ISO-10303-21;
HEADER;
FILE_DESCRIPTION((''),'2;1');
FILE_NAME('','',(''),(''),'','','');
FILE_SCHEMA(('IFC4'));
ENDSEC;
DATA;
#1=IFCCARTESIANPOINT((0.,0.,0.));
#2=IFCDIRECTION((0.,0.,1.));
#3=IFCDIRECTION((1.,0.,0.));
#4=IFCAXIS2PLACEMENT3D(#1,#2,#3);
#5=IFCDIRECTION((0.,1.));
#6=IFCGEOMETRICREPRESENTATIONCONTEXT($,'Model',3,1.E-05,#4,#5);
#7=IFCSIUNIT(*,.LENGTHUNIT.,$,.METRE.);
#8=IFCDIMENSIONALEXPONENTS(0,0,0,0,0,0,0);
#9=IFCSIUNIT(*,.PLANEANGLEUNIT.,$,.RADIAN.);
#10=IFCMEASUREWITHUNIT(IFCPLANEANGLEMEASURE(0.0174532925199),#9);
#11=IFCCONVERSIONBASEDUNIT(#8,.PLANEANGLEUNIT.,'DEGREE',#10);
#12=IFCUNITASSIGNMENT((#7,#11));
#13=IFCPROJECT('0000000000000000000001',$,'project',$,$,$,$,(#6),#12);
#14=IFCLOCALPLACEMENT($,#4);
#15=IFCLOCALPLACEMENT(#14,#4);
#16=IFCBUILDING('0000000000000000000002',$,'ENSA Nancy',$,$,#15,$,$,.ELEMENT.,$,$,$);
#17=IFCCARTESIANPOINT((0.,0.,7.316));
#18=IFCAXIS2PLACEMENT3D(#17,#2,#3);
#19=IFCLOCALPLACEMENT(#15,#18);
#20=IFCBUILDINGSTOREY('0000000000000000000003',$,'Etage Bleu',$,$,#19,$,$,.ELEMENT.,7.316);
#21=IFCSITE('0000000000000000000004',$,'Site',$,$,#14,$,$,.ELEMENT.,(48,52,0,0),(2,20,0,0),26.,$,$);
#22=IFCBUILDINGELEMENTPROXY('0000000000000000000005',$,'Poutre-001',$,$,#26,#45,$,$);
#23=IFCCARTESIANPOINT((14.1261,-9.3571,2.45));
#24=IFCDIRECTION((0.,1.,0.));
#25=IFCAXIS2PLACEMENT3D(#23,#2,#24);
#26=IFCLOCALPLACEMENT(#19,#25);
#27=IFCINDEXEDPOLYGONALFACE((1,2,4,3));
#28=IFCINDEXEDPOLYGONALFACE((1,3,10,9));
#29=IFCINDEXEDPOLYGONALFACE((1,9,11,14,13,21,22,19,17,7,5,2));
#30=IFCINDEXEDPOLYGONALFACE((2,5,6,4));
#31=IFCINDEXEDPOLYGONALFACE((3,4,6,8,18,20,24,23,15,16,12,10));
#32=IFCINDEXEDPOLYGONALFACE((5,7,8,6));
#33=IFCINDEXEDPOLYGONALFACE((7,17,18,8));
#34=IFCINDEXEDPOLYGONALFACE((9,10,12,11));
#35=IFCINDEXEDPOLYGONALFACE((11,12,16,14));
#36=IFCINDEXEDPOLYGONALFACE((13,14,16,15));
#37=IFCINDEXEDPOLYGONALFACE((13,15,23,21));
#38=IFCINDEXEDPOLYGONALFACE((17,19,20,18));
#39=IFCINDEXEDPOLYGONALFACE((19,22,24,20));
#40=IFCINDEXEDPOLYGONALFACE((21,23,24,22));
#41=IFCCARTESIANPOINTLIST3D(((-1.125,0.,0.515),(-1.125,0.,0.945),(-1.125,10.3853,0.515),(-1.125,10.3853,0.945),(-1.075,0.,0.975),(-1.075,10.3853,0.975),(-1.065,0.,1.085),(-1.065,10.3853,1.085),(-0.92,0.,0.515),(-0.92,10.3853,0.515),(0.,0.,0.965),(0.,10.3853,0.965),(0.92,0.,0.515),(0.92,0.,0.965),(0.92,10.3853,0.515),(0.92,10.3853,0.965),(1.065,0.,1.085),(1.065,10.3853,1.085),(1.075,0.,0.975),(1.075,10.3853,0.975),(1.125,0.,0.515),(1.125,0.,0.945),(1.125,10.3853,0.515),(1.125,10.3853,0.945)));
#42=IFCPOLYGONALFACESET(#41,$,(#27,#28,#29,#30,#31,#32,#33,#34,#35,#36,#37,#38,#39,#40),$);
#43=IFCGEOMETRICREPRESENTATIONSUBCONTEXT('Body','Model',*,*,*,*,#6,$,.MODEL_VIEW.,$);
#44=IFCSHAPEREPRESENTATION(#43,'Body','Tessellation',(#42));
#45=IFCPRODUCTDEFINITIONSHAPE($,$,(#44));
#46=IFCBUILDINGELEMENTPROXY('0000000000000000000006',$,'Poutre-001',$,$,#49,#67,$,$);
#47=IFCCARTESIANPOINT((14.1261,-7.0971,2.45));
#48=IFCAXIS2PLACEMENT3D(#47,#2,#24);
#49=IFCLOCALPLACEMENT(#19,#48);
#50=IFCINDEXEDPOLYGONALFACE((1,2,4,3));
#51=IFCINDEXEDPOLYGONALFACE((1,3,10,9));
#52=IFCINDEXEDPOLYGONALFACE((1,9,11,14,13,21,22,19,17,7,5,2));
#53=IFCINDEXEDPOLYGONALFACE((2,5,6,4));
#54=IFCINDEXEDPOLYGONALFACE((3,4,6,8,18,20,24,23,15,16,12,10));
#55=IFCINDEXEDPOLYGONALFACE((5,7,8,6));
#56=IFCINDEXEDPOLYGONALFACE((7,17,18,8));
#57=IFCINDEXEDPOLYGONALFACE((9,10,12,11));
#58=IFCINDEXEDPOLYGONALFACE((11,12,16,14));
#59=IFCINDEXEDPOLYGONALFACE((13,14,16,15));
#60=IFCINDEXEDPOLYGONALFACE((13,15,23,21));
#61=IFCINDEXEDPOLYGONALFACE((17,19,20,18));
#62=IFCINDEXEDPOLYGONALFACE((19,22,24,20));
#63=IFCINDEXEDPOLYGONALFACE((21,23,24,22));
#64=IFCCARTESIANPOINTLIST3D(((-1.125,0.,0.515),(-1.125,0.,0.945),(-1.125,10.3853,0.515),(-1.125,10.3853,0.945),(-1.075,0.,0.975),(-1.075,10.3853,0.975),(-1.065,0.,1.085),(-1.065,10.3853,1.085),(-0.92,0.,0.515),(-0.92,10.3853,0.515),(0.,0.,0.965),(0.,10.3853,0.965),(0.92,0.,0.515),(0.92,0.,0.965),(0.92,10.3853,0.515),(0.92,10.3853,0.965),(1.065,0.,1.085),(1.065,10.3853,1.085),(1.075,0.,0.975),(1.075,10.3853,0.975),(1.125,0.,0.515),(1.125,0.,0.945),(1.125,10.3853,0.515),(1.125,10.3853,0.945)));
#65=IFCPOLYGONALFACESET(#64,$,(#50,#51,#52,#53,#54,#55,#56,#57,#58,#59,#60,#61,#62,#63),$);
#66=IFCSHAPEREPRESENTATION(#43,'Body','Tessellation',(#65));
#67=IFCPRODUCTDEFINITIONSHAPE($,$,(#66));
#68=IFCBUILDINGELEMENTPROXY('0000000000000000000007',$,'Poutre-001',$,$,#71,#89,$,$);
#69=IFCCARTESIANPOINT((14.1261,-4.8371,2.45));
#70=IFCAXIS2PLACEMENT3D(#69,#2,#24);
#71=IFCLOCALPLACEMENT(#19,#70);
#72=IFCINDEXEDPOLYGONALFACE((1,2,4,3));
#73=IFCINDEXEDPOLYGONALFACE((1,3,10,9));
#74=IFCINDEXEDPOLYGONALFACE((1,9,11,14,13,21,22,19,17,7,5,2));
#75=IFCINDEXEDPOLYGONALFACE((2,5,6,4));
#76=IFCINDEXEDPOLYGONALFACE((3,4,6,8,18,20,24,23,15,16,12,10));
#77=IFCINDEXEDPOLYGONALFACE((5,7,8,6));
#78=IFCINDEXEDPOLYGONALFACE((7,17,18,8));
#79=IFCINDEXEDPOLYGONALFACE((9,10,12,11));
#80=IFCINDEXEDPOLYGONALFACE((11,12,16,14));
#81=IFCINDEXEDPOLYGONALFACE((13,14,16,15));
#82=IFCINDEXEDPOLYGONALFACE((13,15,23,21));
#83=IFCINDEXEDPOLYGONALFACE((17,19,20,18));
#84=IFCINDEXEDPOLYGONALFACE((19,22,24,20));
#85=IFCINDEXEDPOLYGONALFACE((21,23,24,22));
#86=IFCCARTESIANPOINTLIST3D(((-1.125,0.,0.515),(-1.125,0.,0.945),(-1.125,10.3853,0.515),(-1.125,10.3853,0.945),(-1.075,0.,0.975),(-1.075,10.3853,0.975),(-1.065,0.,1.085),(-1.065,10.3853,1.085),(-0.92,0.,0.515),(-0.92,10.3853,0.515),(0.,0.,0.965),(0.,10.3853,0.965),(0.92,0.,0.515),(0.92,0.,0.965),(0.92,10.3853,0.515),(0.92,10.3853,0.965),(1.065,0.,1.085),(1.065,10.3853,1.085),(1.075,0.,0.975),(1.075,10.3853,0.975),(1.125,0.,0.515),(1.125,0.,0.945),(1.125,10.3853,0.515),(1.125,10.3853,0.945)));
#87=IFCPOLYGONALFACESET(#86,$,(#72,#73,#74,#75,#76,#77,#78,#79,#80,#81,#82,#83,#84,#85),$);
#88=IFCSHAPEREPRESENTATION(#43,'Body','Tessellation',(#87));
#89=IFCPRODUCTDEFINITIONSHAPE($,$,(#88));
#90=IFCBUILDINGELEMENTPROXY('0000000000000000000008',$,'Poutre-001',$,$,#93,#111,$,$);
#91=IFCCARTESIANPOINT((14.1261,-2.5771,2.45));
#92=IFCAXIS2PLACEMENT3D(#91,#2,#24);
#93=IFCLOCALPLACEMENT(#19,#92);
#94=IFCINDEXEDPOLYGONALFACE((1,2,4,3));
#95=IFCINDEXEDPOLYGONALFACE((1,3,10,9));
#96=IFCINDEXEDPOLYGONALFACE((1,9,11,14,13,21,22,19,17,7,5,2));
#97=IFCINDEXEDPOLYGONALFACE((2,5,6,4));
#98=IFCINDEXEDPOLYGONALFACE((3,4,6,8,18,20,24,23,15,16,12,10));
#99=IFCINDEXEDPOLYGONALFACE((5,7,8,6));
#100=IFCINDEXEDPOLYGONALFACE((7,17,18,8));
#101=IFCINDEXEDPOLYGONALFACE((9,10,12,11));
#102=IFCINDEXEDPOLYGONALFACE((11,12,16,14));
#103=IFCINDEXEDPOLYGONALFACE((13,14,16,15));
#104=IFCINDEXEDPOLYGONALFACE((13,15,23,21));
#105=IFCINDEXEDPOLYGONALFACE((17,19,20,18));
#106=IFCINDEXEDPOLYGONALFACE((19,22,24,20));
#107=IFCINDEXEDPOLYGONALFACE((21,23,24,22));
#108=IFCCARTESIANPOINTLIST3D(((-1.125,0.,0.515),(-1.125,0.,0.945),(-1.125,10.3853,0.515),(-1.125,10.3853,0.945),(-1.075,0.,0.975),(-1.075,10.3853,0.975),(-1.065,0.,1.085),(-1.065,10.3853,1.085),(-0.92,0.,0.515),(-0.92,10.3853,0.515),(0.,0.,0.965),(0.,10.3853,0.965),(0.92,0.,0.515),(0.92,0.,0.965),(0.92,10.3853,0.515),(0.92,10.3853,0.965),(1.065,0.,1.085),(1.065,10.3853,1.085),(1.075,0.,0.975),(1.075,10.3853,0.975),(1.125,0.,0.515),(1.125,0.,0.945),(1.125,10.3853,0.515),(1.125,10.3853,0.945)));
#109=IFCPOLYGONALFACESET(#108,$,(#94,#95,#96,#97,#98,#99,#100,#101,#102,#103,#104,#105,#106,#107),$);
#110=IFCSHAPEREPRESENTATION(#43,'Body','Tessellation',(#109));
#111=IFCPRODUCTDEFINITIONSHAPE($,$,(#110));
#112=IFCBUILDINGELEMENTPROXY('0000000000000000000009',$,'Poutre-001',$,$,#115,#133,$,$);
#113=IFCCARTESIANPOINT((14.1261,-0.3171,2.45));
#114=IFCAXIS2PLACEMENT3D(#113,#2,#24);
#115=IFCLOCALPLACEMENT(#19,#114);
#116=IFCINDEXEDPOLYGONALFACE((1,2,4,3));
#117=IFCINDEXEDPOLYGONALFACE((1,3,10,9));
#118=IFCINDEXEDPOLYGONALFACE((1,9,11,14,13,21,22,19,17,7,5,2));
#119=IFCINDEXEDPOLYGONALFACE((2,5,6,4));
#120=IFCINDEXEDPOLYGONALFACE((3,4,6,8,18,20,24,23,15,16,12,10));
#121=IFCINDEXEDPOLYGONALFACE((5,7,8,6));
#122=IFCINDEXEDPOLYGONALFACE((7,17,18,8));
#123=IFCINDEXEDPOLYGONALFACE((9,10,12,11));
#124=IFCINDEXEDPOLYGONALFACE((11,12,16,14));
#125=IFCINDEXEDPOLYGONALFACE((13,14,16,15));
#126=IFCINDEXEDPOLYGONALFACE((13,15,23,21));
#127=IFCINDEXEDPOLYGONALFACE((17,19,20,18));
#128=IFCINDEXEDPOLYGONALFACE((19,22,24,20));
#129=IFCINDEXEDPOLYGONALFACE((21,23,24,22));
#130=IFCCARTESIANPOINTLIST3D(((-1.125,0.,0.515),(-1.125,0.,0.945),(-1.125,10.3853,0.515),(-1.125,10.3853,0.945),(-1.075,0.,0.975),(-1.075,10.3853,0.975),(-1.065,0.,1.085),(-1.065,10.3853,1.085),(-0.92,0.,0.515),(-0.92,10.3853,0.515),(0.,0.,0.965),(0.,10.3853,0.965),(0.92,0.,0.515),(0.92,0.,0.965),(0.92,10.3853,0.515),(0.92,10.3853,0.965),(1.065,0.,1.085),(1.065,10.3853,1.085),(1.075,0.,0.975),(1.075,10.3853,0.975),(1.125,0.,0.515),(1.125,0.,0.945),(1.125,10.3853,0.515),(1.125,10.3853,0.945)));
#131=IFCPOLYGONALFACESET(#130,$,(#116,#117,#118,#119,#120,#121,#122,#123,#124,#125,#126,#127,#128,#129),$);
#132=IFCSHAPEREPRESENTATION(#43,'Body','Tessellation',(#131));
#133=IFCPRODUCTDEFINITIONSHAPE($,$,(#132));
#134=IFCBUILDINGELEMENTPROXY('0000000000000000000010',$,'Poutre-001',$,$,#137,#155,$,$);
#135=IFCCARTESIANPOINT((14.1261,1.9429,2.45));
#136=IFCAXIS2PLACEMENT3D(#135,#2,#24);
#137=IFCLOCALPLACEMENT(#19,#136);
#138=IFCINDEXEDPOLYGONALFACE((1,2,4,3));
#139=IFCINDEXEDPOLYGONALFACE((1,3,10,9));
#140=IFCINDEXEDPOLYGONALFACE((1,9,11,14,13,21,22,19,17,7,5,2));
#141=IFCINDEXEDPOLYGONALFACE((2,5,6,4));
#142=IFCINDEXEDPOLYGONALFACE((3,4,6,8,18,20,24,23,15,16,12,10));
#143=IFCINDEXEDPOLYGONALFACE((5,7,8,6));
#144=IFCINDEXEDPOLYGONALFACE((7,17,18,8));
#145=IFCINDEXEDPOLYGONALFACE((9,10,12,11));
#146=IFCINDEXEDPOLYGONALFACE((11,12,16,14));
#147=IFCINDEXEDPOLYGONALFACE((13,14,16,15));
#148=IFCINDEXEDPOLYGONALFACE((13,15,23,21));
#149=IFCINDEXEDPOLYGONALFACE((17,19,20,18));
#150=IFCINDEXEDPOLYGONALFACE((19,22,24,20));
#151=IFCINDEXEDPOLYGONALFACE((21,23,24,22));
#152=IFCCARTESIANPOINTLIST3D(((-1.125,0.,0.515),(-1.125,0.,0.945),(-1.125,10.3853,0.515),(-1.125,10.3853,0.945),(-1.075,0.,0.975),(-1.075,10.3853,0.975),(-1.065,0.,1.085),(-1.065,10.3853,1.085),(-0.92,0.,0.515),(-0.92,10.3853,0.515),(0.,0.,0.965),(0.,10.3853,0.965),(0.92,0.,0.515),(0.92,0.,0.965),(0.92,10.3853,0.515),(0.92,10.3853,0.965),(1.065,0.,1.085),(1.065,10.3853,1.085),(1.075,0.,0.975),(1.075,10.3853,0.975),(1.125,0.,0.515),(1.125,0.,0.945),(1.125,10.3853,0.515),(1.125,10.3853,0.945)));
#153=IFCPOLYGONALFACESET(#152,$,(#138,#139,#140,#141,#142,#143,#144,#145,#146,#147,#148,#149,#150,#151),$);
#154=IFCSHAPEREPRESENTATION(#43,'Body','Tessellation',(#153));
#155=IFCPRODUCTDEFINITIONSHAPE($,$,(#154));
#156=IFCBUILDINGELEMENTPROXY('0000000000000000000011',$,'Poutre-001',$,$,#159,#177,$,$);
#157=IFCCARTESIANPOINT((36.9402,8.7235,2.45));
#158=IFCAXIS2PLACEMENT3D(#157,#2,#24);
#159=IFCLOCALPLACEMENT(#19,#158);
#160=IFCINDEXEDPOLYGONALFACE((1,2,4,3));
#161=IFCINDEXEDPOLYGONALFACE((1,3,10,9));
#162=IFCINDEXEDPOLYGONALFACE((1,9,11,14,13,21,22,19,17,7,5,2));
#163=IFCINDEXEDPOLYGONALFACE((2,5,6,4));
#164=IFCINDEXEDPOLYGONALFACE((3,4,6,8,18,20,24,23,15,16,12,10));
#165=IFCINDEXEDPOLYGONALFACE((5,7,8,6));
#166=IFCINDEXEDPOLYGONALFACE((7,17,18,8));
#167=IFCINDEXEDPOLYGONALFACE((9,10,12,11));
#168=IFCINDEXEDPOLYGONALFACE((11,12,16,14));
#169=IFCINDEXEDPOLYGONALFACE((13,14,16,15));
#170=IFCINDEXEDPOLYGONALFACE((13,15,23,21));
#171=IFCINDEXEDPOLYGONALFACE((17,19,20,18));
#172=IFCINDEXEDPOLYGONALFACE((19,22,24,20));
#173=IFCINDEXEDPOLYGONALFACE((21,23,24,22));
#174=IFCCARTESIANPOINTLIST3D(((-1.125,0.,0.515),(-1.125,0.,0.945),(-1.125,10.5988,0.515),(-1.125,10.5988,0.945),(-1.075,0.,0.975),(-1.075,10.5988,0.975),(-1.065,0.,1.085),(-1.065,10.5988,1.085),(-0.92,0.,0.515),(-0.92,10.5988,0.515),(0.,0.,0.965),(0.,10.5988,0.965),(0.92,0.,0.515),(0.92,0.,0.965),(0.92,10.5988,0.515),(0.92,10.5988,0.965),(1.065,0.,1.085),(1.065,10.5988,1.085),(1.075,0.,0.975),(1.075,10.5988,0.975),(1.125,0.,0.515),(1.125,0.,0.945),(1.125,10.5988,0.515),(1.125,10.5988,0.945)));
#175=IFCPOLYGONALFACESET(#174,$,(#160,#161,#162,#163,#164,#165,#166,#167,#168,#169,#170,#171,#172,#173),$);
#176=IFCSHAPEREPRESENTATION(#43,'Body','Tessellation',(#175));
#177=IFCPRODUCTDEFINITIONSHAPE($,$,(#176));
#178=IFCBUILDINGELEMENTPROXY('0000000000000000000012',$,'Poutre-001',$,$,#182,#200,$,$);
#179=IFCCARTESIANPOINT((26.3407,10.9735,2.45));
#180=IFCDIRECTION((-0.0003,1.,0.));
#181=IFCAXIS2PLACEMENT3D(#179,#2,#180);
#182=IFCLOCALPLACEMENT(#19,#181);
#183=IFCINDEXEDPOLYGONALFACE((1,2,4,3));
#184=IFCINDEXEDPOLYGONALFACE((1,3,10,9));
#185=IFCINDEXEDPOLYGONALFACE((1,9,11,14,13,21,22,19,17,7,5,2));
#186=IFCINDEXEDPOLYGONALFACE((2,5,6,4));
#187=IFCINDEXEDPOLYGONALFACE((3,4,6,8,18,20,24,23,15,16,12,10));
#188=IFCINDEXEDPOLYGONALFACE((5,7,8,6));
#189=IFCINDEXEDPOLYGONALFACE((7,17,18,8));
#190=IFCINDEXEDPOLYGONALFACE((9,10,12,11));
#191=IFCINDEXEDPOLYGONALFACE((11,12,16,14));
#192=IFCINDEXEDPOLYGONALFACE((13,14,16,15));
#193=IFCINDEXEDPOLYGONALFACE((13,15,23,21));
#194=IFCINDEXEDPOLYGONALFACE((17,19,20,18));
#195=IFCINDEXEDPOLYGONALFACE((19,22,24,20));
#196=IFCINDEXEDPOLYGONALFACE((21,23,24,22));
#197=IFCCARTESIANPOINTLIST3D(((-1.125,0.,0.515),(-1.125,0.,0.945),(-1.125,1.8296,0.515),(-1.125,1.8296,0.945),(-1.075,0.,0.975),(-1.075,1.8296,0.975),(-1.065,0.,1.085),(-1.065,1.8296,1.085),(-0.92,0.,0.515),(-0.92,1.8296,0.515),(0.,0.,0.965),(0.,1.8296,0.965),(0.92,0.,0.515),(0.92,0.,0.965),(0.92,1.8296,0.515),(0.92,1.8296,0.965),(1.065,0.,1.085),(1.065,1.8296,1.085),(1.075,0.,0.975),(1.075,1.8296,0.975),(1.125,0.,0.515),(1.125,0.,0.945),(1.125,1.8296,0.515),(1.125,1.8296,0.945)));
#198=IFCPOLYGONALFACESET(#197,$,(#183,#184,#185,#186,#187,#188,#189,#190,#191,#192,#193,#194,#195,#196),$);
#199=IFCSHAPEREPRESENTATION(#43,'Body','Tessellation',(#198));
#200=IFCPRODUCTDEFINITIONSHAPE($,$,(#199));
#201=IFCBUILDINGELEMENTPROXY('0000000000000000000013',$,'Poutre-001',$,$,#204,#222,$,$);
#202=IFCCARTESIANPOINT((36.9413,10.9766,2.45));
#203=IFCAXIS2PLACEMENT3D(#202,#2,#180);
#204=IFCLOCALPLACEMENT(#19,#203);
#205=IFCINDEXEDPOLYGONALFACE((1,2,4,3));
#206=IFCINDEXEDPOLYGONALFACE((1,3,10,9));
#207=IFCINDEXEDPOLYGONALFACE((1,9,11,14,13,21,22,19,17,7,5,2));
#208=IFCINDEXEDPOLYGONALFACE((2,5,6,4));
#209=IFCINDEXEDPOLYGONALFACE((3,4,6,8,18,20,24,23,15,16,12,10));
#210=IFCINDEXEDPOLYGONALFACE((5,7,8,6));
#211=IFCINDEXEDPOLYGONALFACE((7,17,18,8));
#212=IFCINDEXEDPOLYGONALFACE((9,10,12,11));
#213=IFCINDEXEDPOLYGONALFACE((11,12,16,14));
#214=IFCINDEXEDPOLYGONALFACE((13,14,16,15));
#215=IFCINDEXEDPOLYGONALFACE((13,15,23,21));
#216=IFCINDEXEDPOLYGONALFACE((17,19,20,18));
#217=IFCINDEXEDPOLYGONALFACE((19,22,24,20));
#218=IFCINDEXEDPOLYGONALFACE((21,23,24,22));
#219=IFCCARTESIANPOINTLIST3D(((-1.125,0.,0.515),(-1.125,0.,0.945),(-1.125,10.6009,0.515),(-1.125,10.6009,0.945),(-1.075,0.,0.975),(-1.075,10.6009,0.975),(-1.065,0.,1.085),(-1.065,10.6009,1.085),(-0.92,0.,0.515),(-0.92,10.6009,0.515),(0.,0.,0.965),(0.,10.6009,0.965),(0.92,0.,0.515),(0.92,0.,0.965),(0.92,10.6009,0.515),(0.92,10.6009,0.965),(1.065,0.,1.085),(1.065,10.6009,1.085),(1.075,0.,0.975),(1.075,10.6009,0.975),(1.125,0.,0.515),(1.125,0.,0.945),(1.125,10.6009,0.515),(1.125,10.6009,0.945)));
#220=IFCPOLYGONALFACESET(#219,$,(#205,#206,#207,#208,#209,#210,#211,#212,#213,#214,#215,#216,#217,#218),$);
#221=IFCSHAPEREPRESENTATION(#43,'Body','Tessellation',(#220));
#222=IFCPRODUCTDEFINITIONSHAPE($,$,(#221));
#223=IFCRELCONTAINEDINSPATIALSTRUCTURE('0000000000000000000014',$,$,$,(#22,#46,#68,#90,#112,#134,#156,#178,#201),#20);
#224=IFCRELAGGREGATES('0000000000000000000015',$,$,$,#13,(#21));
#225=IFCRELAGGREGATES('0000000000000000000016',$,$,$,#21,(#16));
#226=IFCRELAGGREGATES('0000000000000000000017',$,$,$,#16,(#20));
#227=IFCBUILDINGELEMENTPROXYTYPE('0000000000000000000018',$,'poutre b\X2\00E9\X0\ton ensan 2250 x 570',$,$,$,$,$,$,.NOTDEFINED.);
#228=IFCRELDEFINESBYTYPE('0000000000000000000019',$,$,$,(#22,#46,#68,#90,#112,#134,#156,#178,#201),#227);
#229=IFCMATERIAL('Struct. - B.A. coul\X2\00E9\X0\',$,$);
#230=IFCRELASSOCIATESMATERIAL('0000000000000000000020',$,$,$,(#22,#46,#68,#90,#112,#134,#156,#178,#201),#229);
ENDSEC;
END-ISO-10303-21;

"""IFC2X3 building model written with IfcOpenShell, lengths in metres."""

from ifc_helpers import new_model, entity, si_unit, converted_unit, direction, frame, origin_with_axes, place, context, subcontext, project, spatial, polyline, outline, extrude, material, type_object, element, save


model = new_model("IFC2X3")

# Units and contexts
model_context = context("Model", 3, precision=1e-05, world=origin_with_axes(), true_north=direction((0.0, 1.0)))
body_context = subcontext(model_context, "Body", "Model", "MODEL_VIEW")
ifc_project = project(units=[si_unit("LENGTHUNIT", "METRE"), converted_unit("PLANEANGLEUNIT", "DEGREE", entity("IfcPlaneAngleMeasure", 0.0174532925199), si_unit("PLANEANGLEUNIT", "RADIAN"), dimensions=[0, 0, 0, 0, 0, 0, 0])], contexts=[model_context])

# Site, building, storey
site_placement = place(None, origin_with_axes())
site = spatial("IfcSite", under=ifc_project, at=site_placement, Name="Site", CompositionType="ELEMENT", RefLatitude=(48, 52, 0, 0), RefLongitude=(2, 20, 0, 0), RefElevation=26.0)
building_placement = place(site_placement, origin_with_axes())
building = spatial("IfcBuilding", under=site, at=building_placement, Name="ENSA Nancy", CompositionType="ELEMENT")
storey_placement = place(building_placement, frame((0.0, 0.0, 7.316), z_axis=(0.0, 0.0, 1.0), x_axis=(1.0, 0.0, 0.0)))
storey = spatial("IfcBuildingStorey", under=building, at=storey_placement, Name="Etage Bleu", CompositionType="ELEMENT", Elevation=7.316)

# Building element proxies
ifc_material_1 = material(Name="Struct. - B.A. coulé")
building_element_proxy_type_1 = type_object("IfcBuildingElementProxyType", Name="poutre béton ensan 2250 x 570", PredefinedType="NOTDEFINED")
for number, where, z_axis, x_axis, name in (
    (1, (14.1261, -9.3571, 2.45), (0.0, 0.0, 1.0), (0.0, 1.0, 0.0), "Poutre-001"),
    (2, (14.1261, -7.0971, 2.45), (0.0, 0.0, 1.0), (0.0, 1.0, 0.0), "Poutre-001"),
    (3, (14.1261, -4.8371, 2.45), (0.0, 0.0, 1.0), (0.0, 1.0, 0.0), "Poutre-001"),
    (4, (14.1261, -2.5771, 2.45), (0.0, 0.0, 1.0), (0.0, 1.0, 0.0), "Poutre-001"),
    (5, (14.1261, -0.3171, 2.45), (0.0, 0.0, 1.0), (0.0, 1.0, 0.0), "Poutre-001"),
    (6, (14.1261, 1.9429, 2.45), (0.0, 0.0, 1.0), (0.0, 1.0, 0.0), "Poutre-001"),
):
    element("IfcBuildingElementProxy", number, at=place(storey_placement, frame(where, z_axis=z_axis, x_axis=x_axis)), inside=storey, type_object=building_element_proxy_type_1, material=ifc_material_1, Name=name, context=body_context, shape_type="SweptSolid", body=[
        extrude(outline(polyline([(-1.065, 1.085), (-1.075, 0.975), (-1.125, 0.945), (-1.125, 0.515), (-0.92, 0.515), (0.0, 0.965), (0.92, 0.965), (0.92, 0.515), (1.125, 0.515), (1.125, 0.945), (1.075, 0.975), (1.065, 1.085), (-1.065, 1.085)])), frame((0.0, 10.3853, 0.0), z_axis=(0.0, -1.0, 0.0), x_axis=(1.0, 0.0, 0.0)), (0.0, 0.0, 1.0), 10.3853),
    ])
proxy_1_placement = place(storey_placement, frame((36.9402, 8.7235, 2.45), z_axis=(0.0, 0.0, 1.0), x_axis=(0.0, 1.0, 0.0)))
element("IfcBuildingElementProxy", 7, at=proxy_1_placement, inside=storey, type_object=building_element_proxy_type_1, material=ifc_material_1, Name="Poutre-001", context=body_context, shape_type="SweptSolid", body=[
    extrude(outline(polyline([(-1.065, 1.085), (-1.075, 0.975), (-1.125, 0.945), (-1.125, 0.515), (-0.92, 0.515), (0.0, 0.965), (0.92, 0.965), (0.92, 0.515), (1.125, 0.515), (1.125, 0.945), (1.075, 0.975), (1.065, 1.085), (-1.065, 1.085)])), frame((0.0, 10.5988, 0.0), z_axis=(0.0, -1.0, 0.0), x_axis=(1.0, 0.0, 0.0)), (0.0, 0.0, 1.0), 10.5988),
])
proxy_2_placement = place(storey_placement, frame((26.3407, 10.9735, 2.45), z_axis=(0.0, 0.0, 1.0), x_axis=(-0.0003, 1.0, 0.0)))
element("IfcBuildingElementProxy", 8, at=proxy_2_placement, inside=storey, type_object=building_element_proxy_type_1, material=ifc_material_1, Name="Poutre-001", context=body_context, shape_type="SweptSolid", body=[
    extrude(outline(polyline([(-1.065, 1.085), (-1.075, 0.975), (-1.125, 0.945), (-1.125, 0.515), (-0.92, 0.515), (0.0, 0.965), (0.92, 0.965), (0.92, 0.515), (1.125, 0.515), (1.125, 0.945), (1.075, 0.975), (1.065, 1.085), (-1.065, 1.085)])), frame((0.0, 1.8296, 0.0), z_axis=(0.0, -1.0, 0.0), x_axis=(1.0, 0.0, 0.0)), (0.0, 0.0, 1.0), 1.8296),
])
proxy_3_placement = place(storey_placement, frame((36.9413, 10.9766, 2.45), z_axis=(0.0, 0.0, 1.0), x_axis=(-0.0003, 1.0, 0.0)))
element("IfcBuildingElementProxy", 9, at=proxy_3_placement, inside=storey, type_object=building_element_proxy_type_1, material=ifc_material_1, Name="Poutre-001", context=body_context, shape_type="SweptSolid", body=[
    extrude(outline(polyline([(-1.065, 1.085), (-1.075, 0.975), (-1.125, 0.945), (-1.125, 0.515), (-0.92, 0.515), (0.0, 0.965), (0.92, 0.965), (0.92, 0.515), (1.125, 0.515), (1.125, 0.945), (1.075, 0.975), (1.065, 1.085), (-1.065, 1.085)])), frame((0.0, 10.6009, 0.0), z_axis=(0.0, -1.0, 0.0), x_axis=(1.0, 0.0, 0.0)), (0.0, 0.0, 1.0), 10.6009),
])

save(model, "model.ifc")
